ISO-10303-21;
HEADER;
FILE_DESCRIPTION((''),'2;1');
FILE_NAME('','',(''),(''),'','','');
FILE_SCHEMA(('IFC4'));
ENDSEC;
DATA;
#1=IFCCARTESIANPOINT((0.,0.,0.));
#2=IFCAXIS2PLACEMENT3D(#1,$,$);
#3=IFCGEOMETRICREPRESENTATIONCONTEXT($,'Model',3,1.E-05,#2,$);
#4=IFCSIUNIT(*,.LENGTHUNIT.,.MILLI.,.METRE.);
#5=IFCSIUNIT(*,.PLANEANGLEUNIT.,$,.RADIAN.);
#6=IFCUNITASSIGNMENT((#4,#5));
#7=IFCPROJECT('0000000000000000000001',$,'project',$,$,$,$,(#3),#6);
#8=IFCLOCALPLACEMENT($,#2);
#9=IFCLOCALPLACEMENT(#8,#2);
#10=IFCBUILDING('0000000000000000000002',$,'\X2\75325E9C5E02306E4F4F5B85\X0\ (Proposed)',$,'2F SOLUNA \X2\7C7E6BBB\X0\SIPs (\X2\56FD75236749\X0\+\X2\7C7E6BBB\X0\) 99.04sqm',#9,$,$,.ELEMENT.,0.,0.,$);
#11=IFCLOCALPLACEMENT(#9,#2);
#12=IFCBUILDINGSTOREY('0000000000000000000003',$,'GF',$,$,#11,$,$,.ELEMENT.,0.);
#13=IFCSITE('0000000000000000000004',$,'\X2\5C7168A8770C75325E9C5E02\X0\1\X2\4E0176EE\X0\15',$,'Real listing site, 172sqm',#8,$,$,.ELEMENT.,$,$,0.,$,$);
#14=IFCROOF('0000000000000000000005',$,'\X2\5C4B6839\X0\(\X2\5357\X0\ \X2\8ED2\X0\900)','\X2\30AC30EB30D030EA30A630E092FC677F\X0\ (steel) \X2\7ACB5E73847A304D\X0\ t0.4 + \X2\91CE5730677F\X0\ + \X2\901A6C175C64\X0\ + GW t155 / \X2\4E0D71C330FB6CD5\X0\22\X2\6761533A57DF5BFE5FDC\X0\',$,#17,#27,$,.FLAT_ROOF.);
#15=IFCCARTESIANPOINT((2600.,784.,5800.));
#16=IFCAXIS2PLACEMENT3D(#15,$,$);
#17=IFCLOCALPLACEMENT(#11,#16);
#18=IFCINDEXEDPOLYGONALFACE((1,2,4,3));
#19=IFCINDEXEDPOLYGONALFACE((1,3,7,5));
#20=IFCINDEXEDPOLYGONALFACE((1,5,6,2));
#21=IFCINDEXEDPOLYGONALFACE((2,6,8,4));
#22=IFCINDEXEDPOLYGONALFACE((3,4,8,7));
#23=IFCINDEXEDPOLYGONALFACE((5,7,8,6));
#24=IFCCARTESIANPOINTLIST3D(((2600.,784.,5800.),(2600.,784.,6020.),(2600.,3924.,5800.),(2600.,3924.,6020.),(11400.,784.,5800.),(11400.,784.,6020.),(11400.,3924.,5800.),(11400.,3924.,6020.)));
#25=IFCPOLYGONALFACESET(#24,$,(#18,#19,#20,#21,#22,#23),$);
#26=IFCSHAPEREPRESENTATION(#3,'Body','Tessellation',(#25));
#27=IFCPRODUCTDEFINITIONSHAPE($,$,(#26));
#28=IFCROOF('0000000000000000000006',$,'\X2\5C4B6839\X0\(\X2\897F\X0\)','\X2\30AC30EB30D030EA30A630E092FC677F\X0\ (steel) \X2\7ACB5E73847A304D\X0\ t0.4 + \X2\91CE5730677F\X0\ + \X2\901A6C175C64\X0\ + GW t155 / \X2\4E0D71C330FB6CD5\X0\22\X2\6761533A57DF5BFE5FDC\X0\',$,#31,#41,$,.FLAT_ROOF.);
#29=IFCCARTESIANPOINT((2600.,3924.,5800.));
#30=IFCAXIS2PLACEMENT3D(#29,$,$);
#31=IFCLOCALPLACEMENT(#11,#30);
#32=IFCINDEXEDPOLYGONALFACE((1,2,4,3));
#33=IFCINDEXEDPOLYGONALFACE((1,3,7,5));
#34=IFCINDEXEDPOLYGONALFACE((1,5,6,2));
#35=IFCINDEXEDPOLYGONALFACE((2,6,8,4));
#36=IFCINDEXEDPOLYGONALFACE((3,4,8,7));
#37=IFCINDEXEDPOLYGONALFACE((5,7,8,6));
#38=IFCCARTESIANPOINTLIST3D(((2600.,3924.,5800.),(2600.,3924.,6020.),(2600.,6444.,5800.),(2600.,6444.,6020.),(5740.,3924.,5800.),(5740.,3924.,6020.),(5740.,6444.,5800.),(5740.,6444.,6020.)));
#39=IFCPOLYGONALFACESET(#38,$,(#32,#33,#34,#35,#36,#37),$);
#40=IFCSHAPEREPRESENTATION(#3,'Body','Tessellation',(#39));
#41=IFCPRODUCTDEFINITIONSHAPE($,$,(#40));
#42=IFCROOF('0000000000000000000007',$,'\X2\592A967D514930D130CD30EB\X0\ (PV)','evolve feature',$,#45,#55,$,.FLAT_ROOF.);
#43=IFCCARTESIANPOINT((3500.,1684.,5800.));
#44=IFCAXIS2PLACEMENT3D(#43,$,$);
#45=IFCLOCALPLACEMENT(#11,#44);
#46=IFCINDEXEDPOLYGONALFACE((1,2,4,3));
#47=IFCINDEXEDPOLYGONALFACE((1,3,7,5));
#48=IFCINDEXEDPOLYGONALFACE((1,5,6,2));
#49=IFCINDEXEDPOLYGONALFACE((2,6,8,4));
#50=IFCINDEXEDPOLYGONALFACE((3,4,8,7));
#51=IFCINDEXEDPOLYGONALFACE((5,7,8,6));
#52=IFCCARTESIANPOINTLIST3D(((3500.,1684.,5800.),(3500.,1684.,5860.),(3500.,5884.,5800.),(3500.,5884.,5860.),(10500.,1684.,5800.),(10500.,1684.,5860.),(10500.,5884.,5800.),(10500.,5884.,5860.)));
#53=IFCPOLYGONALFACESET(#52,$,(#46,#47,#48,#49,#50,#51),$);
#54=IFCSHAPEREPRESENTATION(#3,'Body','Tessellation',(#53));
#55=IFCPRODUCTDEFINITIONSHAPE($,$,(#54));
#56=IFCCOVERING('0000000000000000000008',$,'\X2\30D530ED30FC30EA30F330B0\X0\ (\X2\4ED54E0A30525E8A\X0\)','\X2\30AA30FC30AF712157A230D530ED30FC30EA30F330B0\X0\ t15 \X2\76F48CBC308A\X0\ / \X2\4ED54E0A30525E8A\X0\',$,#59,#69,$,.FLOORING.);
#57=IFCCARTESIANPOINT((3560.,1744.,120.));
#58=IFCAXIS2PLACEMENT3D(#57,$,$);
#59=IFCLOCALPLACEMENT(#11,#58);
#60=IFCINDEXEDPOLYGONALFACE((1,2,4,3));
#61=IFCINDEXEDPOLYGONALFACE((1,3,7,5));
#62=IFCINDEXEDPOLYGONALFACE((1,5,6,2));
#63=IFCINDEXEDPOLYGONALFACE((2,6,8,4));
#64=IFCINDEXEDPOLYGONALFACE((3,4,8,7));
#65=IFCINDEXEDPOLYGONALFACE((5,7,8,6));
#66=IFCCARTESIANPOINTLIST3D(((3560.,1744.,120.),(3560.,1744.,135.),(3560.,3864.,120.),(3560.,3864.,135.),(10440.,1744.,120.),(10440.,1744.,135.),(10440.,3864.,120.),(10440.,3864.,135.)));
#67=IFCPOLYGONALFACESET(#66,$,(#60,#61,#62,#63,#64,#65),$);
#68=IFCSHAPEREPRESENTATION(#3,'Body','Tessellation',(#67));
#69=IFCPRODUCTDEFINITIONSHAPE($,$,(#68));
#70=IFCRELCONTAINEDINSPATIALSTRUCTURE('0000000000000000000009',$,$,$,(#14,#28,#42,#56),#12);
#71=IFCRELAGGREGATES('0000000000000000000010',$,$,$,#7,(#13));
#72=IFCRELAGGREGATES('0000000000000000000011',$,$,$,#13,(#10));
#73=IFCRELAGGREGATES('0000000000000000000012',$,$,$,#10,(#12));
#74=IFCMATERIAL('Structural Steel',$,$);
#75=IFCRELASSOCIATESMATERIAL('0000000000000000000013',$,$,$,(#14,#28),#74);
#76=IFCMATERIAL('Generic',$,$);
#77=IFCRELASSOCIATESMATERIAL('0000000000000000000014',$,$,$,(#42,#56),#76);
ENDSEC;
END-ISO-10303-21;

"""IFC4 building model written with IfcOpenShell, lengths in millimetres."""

from ifc_helpers import new_model, si_unit, frame, frame_2d, origin, place, context, project, spatial, rectangle, extrude, material, element, save


model = new_model("IFC4")

# Units and contexts
model_context = context("Model", 3, precision=1e-05, world=origin())
ifc_project = project(units=[si_unit("LENGTHUNIT", "METRE", prefix="MILLI"), si_unit("PLANEANGLEUNIT", "RADIAN")], contexts=[model_context])

# Site, building, storey
site_placement = place(None, origin())
site = spatial("IfcSite", under=ifc_project, at=site_placement, Name="山梨県甲府市1丁目15", ObjectType="Real listing site, 172sqm", CompositionType="ELEMENT", RefElevation=0.0)
building_placement = place(site_placement, origin())
building = spatial("IfcBuilding", under=site, at=building_placement, Name="甲府市の住宅 (Proposed)", ObjectType="2F SOLUNA 籾殻SIPs (国産杉+籾殻) 99.04sqm", CompositionType="ELEMENT", ElevationOfRefHeight=0.0, ElevationOfTerrain=0.0)
storey_placement = place(building_placement, origin())
storey = spatial("IfcBuildingStorey", under=building, at=storey_placement, Name="GF", CompositionType="ELEMENT", Elevation=0.0)

# Shared definitions
ifc_material_1 = material(Name="Generic")

# Roofs
ifc_material_2 = material(Name="Structural Steel")
roof_1_placement = place(storey_placement, frame((2600.0, 784.0, 5800.0)))
element("IfcRoof", 1, at=roof_1_placement, inside=storey, material=ifc_material_2, Name="屋根(南 軒900)", Description="ガルバリウム鋼板 (steel) 立平葺き t0.4 + 野地板 + 通気層 + GW t155 / 不燃・法22条区域対応", PredefinedType="FLAT_ROOF", context=model_context, shape_type="SweptSolid", body=[
    extrude(rectangle(XDim=8800.0, YDim=3140.0, at=frame_2d((4400.0, 1570.0))), frame((2600.0, 784.0, 5800.0)), (0.0, 0.0, 1.0), 220.0),
])
roof_2_placement = place(storey_placement, frame((2600.0, 3924.0, 5800.0)))
element("IfcRoof", 2, at=roof_2_placement, inside=storey, material=ifc_material_2, Name="屋根(西)", Description="ガルバリウム鋼板 (steel) 立平葺き t0.4 + 野地板 + 通気層 + GW t155 / 不燃・法22条区域対応", PredefinedType="FLAT_ROOF", context=model_context, shape_type="SweptSolid", body=[
    extrude(rectangle(XDim=3140.0, YDim=2520.0, at=frame_2d((1570.0, 1260.0))), frame((2600.0, 3924.0, 5800.0)), (0.0, 0.0, 1.0), 220.0),
])
roof_3_placement = place(storey_placement, frame((3500.0, 1684.0, 5800.0)))
element("IfcRoof", 3, at=roof_3_placement, inside=storey, material=ifc_material_1, Name="太陽光パネル (PV)", Description="evolve feature", PredefinedType="FLAT_ROOF", context=model_context, shape_type="SweptSolid", body=[
    extrude(rectangle(XDim=7000.0, YDim=4200.0, at=frame_2d((3500.0, 2100.0))), frame((3500.0, 1684.0, 5800.0)), (0.0, 0.0, 1.0), 60.0),
])

# Covering
covering_placement = place(storey_placement, frame((3560.0, 1744.0, 120.0)))
element("IfcCovering", 4, at=covering_placement, inside=storey, material=ifc_material_1, Name="フローリング (仕上げ床)", Description="オーク無垢フローリング t15 直貼り / 仕上げ床", PredefinedType="FLOORING", context=model_context, shape_type="SweptSolid", body=[
    extrude(rectangle(XDim=6880.0, YDim=2120.0, at=frame_2d((3440.0, 1060.0))), frame((3560.0, 1744.0, 120.0)), (0.0, 0.0, 1.0), 15.0),
])

save(model, "model.ifc")
